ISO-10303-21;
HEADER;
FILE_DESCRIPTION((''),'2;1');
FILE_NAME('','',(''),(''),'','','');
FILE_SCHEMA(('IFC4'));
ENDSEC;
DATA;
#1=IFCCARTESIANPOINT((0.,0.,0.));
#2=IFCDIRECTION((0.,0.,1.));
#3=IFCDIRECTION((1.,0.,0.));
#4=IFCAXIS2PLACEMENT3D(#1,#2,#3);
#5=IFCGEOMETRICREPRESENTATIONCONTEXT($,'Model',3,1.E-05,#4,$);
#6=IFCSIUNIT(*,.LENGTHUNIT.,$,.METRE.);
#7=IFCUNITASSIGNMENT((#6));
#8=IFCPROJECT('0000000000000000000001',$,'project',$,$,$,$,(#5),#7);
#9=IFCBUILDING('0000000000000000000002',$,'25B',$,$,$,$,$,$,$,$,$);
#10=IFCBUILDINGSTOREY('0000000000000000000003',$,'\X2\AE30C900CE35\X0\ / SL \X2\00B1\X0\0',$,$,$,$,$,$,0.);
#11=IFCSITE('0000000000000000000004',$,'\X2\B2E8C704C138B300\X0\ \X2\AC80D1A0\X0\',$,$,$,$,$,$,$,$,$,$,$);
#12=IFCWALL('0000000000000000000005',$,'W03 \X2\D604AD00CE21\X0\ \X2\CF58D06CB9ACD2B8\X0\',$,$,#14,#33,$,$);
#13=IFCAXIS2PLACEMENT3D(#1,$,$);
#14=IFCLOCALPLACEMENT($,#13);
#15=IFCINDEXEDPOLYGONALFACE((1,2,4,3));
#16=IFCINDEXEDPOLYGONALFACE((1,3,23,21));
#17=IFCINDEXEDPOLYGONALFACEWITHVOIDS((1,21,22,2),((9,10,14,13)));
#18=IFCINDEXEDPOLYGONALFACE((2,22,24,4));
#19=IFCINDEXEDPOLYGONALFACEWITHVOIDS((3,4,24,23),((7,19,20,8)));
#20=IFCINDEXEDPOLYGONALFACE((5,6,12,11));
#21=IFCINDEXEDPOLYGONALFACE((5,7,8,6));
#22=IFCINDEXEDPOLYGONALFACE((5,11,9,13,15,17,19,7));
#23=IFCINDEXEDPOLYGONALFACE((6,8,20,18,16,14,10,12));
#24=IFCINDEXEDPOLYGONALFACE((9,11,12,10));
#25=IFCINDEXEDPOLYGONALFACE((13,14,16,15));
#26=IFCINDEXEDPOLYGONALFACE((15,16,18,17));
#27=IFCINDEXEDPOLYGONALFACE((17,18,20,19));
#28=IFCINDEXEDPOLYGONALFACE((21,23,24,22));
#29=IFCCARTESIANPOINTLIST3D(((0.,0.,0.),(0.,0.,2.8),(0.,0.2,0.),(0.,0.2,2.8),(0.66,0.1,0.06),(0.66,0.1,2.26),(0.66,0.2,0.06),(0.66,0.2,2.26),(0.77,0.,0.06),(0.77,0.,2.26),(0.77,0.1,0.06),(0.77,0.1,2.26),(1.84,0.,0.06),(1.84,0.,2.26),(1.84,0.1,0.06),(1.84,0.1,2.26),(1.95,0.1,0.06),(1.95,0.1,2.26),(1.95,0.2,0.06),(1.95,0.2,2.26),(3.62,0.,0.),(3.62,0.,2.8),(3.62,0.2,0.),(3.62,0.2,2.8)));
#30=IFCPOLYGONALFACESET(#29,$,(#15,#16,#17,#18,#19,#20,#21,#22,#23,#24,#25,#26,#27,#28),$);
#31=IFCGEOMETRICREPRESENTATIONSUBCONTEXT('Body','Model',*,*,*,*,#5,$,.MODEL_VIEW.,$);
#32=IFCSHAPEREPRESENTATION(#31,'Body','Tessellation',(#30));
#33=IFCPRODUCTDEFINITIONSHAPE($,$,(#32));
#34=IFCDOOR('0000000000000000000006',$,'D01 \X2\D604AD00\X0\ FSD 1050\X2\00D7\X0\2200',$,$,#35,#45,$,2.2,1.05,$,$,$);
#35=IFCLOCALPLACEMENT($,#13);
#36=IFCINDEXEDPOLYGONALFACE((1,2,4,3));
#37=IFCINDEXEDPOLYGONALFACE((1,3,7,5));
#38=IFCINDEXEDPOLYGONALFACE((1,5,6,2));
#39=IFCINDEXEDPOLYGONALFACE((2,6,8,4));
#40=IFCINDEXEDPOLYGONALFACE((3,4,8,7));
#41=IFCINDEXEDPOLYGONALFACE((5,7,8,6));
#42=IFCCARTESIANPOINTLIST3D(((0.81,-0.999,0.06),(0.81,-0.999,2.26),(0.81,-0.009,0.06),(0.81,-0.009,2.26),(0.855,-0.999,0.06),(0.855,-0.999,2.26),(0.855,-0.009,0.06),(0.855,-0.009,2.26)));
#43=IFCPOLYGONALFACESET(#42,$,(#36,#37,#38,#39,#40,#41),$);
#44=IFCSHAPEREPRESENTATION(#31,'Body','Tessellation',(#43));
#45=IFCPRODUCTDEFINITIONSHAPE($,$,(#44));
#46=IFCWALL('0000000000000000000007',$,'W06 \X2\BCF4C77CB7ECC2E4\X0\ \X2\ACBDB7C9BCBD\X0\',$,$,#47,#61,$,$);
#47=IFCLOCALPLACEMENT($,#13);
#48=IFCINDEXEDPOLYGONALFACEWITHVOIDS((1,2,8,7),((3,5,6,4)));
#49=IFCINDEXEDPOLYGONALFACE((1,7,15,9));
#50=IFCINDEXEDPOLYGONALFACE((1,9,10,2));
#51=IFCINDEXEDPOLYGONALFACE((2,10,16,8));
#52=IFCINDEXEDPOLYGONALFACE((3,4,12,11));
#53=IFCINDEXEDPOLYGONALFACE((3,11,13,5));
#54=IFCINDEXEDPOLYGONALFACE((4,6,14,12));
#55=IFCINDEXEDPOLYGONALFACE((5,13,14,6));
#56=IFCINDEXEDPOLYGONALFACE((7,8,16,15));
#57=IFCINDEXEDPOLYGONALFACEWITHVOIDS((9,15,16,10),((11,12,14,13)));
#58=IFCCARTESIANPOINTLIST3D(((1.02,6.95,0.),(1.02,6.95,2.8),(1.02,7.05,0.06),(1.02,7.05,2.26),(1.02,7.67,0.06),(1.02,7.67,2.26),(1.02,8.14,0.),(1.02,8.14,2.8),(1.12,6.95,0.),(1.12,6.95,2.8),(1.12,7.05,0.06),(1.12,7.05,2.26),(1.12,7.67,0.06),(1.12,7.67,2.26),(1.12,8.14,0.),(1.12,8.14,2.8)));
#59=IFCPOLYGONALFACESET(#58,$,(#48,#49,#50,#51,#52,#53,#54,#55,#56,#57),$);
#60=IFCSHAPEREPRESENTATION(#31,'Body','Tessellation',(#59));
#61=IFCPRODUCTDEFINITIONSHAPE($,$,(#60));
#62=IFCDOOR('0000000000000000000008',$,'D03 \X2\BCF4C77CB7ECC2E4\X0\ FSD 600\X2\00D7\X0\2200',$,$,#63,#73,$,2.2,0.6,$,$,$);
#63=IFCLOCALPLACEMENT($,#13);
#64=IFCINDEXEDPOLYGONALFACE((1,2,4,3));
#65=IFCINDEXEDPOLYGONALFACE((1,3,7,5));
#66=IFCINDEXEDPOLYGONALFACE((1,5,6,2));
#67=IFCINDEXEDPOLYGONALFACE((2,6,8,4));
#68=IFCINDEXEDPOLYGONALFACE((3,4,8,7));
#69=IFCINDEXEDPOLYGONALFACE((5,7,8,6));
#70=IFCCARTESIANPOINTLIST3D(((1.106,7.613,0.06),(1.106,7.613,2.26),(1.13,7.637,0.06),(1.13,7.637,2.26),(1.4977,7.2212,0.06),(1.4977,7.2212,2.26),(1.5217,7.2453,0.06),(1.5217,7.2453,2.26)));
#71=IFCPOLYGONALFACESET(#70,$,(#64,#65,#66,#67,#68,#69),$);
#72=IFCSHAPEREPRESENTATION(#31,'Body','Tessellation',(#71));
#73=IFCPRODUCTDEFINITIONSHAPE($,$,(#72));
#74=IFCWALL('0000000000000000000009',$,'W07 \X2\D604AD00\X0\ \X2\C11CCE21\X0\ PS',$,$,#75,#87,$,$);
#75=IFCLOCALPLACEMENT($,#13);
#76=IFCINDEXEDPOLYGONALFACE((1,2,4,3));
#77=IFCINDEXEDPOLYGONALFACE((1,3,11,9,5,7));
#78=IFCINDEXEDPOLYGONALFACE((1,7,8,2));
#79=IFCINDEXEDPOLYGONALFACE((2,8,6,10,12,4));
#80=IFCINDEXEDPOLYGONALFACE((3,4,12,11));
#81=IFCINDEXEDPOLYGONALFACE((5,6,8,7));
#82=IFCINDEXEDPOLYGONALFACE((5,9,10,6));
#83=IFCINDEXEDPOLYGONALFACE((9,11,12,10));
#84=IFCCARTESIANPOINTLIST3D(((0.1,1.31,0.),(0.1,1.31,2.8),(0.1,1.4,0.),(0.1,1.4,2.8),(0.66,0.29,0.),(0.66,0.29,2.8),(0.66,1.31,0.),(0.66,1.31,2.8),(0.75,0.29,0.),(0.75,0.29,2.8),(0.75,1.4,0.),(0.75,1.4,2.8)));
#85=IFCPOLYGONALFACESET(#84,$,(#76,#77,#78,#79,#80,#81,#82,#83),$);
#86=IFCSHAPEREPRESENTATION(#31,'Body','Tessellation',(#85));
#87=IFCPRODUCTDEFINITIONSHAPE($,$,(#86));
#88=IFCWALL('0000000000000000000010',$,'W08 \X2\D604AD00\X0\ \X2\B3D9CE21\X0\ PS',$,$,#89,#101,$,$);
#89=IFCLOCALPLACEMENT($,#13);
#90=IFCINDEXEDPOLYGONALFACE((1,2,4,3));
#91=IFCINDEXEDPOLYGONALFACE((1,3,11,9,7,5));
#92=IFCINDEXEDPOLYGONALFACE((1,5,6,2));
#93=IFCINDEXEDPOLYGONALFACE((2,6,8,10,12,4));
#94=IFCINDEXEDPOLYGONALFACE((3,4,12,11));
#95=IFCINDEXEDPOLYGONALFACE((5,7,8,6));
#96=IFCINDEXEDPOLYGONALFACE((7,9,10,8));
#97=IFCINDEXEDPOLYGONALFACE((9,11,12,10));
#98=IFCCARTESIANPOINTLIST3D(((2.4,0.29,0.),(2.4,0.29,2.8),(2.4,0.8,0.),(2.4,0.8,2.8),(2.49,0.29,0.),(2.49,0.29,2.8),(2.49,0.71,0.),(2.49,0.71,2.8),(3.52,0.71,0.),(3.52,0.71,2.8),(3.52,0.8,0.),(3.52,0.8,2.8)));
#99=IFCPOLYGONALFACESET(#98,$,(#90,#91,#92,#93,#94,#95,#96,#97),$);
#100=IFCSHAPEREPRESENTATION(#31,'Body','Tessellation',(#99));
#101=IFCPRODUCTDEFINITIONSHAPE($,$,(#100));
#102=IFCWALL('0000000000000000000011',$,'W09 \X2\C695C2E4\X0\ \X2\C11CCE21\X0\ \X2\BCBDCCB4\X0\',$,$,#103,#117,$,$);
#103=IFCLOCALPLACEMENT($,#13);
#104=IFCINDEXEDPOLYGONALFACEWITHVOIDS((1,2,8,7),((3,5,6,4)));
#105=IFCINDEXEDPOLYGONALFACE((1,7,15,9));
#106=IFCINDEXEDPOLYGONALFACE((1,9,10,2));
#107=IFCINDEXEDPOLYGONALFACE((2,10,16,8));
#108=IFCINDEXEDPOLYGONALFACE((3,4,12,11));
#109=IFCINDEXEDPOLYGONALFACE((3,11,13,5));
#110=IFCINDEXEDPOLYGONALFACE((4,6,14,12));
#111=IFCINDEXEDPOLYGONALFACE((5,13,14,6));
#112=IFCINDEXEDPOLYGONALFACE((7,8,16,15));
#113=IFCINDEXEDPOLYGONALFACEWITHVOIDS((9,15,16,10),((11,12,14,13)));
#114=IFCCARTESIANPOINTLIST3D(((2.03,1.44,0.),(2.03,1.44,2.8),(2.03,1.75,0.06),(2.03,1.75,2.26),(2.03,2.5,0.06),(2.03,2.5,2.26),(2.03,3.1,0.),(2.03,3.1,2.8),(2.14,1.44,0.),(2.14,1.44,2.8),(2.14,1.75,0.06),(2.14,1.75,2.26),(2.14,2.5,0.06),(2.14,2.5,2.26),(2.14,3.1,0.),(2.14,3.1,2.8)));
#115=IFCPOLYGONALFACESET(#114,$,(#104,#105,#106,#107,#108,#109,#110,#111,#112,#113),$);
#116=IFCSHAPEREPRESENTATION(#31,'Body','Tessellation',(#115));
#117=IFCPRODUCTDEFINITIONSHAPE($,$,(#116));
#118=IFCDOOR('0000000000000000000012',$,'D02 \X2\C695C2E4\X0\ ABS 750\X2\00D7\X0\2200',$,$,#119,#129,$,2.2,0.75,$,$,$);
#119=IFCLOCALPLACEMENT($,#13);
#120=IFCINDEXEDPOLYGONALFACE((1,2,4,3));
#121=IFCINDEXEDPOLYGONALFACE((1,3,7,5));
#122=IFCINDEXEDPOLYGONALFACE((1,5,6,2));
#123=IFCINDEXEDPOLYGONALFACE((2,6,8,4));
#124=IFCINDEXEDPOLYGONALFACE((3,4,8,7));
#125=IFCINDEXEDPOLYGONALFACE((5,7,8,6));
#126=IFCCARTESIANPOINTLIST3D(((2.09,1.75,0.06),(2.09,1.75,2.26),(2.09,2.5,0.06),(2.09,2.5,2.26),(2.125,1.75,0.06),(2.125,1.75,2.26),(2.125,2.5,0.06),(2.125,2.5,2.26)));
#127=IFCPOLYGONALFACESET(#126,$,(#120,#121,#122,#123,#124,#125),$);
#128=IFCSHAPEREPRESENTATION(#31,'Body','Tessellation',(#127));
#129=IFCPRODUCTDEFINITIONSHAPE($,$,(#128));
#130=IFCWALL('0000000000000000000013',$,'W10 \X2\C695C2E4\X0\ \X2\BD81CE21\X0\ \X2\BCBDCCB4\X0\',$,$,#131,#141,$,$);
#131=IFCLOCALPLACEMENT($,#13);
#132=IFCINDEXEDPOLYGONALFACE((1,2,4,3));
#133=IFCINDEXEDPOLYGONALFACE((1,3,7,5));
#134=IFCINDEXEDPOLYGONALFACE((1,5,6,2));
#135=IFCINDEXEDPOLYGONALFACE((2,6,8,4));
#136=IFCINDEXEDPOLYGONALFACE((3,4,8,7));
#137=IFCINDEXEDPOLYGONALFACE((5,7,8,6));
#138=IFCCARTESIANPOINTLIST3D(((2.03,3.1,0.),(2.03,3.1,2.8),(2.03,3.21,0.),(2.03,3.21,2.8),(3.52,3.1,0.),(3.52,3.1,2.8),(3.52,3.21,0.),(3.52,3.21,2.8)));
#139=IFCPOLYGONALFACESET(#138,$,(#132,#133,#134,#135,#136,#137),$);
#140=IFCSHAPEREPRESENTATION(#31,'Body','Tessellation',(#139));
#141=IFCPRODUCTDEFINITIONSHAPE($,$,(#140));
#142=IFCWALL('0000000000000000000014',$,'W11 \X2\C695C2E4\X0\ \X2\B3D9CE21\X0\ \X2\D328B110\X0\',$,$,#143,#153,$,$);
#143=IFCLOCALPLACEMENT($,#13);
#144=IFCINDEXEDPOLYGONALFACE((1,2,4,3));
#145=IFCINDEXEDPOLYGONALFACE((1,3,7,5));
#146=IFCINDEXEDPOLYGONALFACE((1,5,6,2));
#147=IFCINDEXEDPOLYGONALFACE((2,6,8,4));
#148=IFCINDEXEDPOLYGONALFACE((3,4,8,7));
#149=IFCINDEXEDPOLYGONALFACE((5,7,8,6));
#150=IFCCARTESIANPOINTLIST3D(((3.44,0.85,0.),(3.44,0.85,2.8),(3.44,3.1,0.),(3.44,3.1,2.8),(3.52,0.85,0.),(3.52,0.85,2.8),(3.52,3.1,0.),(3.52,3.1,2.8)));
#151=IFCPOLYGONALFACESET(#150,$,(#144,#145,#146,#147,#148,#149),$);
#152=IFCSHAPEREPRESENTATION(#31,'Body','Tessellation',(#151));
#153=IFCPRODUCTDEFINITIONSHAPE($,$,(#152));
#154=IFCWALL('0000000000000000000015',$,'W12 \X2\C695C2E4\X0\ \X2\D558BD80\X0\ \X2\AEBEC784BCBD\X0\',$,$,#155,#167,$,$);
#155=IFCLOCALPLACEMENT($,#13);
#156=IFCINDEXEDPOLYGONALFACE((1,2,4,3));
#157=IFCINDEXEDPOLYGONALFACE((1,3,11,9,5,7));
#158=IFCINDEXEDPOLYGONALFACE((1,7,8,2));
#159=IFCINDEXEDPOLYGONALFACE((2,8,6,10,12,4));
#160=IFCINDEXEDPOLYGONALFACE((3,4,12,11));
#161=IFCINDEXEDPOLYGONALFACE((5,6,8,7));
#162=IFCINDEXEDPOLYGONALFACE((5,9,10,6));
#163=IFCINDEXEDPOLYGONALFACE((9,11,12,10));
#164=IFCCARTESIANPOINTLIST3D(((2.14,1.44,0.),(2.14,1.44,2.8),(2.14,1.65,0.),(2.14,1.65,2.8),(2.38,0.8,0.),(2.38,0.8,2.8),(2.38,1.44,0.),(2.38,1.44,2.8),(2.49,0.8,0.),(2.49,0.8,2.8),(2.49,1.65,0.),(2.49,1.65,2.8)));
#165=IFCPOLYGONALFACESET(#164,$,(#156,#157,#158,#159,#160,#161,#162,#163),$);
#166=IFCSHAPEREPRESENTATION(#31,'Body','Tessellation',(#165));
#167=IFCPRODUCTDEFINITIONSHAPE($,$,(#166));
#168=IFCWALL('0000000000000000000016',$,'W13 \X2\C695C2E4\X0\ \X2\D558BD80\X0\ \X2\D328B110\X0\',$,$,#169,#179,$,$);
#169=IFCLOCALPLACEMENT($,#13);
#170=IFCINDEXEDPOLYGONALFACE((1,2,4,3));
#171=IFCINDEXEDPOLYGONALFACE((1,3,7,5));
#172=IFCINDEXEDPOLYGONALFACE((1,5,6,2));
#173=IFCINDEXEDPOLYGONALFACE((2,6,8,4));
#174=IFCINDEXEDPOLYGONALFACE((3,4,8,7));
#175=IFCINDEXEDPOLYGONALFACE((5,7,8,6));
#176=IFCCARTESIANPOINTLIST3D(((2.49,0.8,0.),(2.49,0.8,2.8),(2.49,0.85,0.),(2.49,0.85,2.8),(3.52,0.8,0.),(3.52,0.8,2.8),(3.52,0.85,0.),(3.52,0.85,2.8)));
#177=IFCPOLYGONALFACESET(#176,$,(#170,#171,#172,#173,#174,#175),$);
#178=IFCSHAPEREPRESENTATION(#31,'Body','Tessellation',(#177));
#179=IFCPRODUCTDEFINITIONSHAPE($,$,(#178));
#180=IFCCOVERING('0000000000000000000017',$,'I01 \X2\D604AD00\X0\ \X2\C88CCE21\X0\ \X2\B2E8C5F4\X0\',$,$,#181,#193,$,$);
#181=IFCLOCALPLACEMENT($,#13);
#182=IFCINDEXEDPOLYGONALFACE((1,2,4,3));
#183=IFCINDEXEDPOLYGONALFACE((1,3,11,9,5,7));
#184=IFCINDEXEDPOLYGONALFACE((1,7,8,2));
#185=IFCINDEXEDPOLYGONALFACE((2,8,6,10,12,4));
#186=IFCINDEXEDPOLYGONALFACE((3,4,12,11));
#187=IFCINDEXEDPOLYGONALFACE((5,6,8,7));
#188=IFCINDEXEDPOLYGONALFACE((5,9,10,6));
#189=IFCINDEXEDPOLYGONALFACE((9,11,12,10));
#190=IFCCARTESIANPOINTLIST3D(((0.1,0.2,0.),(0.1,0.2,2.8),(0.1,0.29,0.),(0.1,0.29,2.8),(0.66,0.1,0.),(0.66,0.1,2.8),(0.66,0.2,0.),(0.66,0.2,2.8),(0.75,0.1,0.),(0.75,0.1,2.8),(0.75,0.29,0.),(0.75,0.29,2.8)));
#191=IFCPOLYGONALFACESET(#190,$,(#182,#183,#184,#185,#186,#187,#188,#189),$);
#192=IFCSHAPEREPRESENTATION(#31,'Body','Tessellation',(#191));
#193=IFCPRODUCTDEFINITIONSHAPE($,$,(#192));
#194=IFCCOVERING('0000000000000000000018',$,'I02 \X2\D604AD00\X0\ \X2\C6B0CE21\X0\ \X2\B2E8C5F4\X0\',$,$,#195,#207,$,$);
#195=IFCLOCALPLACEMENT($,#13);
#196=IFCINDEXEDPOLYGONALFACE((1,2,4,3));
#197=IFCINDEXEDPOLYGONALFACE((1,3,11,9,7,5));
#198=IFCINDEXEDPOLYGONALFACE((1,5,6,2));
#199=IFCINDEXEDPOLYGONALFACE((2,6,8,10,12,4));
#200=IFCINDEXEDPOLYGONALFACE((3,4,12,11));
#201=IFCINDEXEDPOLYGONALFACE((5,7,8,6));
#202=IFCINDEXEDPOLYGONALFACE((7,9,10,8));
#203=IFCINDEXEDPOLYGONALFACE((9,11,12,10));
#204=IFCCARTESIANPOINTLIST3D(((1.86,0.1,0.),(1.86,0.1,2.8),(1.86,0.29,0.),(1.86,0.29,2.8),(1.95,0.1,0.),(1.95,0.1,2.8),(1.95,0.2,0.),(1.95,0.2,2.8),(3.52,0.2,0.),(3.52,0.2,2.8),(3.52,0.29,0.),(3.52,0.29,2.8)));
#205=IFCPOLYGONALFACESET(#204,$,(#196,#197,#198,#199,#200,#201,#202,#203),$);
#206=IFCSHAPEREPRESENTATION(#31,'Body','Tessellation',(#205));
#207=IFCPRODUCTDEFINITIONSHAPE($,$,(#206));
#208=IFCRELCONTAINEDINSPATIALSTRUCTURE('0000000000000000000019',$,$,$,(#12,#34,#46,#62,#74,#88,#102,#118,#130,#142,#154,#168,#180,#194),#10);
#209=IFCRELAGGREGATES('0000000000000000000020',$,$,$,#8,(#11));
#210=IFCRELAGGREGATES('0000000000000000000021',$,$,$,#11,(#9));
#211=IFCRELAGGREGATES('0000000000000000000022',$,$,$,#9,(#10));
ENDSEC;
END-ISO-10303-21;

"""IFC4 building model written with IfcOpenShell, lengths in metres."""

from ifc_helpers import new_model, si_unit, frame, origin, origin_with_axes, place, context, subcontext, project, spatial, polyline, outline, extrude, element, fill, save


model = new_model("IFC4")

# Units and contexts
model_context = context("Model", 3, precision=1e-05, world=origin_with_axes())
body_context = subcontext(model_context, "Body", "Model", "MODEL_VIEW")
ifc_project = project(units=[si_unit("LENGTHUNIT", "METRE")], contexts=[model_context])

# Site, building, storey
site = spatial("IfcSite", under=ifc_project, Name="단위세대 검토")
building = spatial("IfcBuilding", under=site, Name="25B")
storey = spatial("IfcBuildingStorey", under=building, Name="기준층 / SL ±0", Elevation=0.0)

# Wall, opening, door
wall_1_placement = place(None, origin_with_axes())
wall_1 = element("IfcWall", 1, at=wall_1_placement, inside=storey, Name="W03 현관측 콘크리트", context=body_context, shape_type="SweptSolid", body=[
    extrude(outline(polyline([(3.62, 0.0), (3.62, 0.2), (0.0, 0.2), (0.0, 0.0), (3.62, 0.0)])), origin(), (0.0, 0.0, 1.0), 2.8),
])
opening_1_placement = place(wall_1_placement, origin_with_axes())
opening_1 = element("IfcOpeningElement", 2, at=opening_1_placement, cuts=wall_1, context=body_context, shape_type="SweptSolid", body=[
    extrude(outline(polyline([(0.77, -0.001), (1.84, -0.001), (1.84, 0.1), (1.95, 0.1), (1.95, 0.201), (0.66, 0.201), (0.66, 0.1), (0.77, 0.1), (0.77, -0.001)])), frame((0.0, 0.0, 0.06)), (0.0, 0.0, 1.0), 2.2),
])
door_1_placement = place(None, origin_with_axes())
door_1 = element("IfcDoor", 3, at=door_1_placement, inside=storey, Name="D01 현관 FSD 1050×2200", OverallHeight=2.2, OverallWidth=1.05, context=body_context, shape_type="SweptSolid", body=[
    extrude(outline(polyline([(0.855, -0.009), (0.855, -0.999), (0.81, -0.999), (0.81, -0.009), (0.855, -0.009)])), frame((0.0, 0.0, 0.06)), (0.0, 0.0, 1.0), 2.2),
])
fill(opening_1, door_1)

# Wall, opening, door
wall_2_placement = place(None, origin_with_axes())
wall_2 = element("IfcWall", 4, at=wall_2_placement, inside=storey, Name="W06 보일러실 경량벽", context=body_context, shape_type="SweptSolid", body=[
    extrude(outline(polyline([(1.12, 6.95), (1.12, 8.14), (1.02, 8.14), (1.02, 6.95), (1.12, 6.95)])), origin(), (0.0, 0.0, 1.0), 2.8),
])
opening_2_placement = place(wall_2_placement, origin_with_axes())
opening_2 = element("IfcOpeningElement", 5, at=opening_2_placement, cuts=wall_2, context=body_context, shape_type="SweptSolid", body=[
    extrude(outline(polyline([(1.121, 7.05), (1.121, 7.67), (1.019, 7.67), (1.019, 7.05), (1.121, 7.05)])), frame((0.0, 0.0, 0.06)), (0.0, 0.0, 1.0), 2.2),
])
door_2_placement = place(None, origin_with_axes())
door_2 = element("IfcDoor", 6, at=door_2_placement, inside=storey, Name="D03 보일러실 FSD 600×2200", OverallHeight=2.2, OverallWidth=0.6, context=body_context, shape_type="SweptSolid", body=[
    extrude(outline(polyline([(1.106, 7.613), (1.13, 7.637), (1.5217, 7.2453), (1.4977, 7.2212), (1.106, 7.613)])), frame((0.0, 0.0, 0.06)), (0.0, 0.0, 1.0), 2.2),
])
fill(opening_2, door_2)

# Walls
wall_3_placement = place(None, origin_with_axes())
element("IfcWall", 7, at=wall_3_placement, inside=storey, Name="W07 현관 서측 PS", context=body_context, shape_type="SweptSolid", body=[
    extrude(outline(polyline([(0.66, 0.29), (0.75, 0.29), (0.75, 1.4), (0.1, 1.4), (0.1, 1.31), (0.66, 1.31), (0.66, 0.29)])), origin(), (0.0, 0.0, 1.0), 2.8),
])
wall_4_placement = place(None, origin_with_axes())
element("IfcWall", 8, at=wall_4_placement, inside=storey, Name="W08 현관 동측 PS", context=body_context, shape_type="SweptSolid", body=[
    extrude(outline(polyline([(2.4, 0.29), (2.49, 0.29), (2.49, 0.71), (3.52, 0.71), (3.52, 0.8), (2.4, 0.8), (2.4, 0.29)])), origin(), (0.0, 0.0, 1.0), 2.8),
])

# Wall, opening, door
wall_5_placement = place(None, origin_with_axes())
wall_5 = element("IfcWall", 9, at=wall_5_placement, inside=storey, Name="W09 욕실 서측 벽체", context=body_context, shape_type="SweptSolid", body=[
    extrude(outline(polyline([(2.14, 1.44), (2.14, 3.1), (2.03, 3.1), (2.03, 1.44), (2.14, 1.44)])), origin(), (0.0, 0.0, 1.0), 2.8),
])
opening_3_placement = place(wall_5_placement, origin_with_axes())
opening_3 = element("IfcOpeningElement", 10, at=opening_3_placement, cuts=wall_5, context=body_context, shape_type="SweptSolid", body=[
    extrude(outline(polyline([(2.141, 1.75), (2.141, 2.5), (2.029, 2.5), (2.029, 1.75), (2.141, 1.75)])), frame((0.0, 0.0, 0.06)), (0.0, 0.0, 1.0), 2.2),
])
door_3_placement = place(None, origin_with_axes())
door_3 = element("IfcDoor", 11, at=door_3_placement, inside=storey, Name="D02 욕실 ABS 750×2200", OverallHeight=2.2, OverallWidth=0.75, context=body_context, shape_type="SweptSolid", body=[
    extrude(outline(polyline([(2.125, 1.75), (2.125, 2.5), (2.09, 2.5), (2.09, 1.75), (2.125, 1.75)])), frame((0.0, 0.0, 0.06)), (0.0, 0.0, 1.0), 2.2),
])
fill(opening_3, door_3)

# Walls
wall_6_placement = place(None, origin_with_axes())
element("IfcWall", 12, at=wall_6_placement, inside=storey, Name="W10 욕실 북측 벽체", context=body_context, shape_type="SweptSolid", body=[
    extrude(outline(polyline([(3.52, 3.1), (3.52, 3.21), (2.03, 3.21), (2.03, 3.1), (3.52, 3.1)])), origin(), (0.0, 0.0, 1.0), 2.8),
])
wall_7_placement = place(None, origin_with_axes())
element("IfcWall", 13, at=wall_7_placement, inside=storey, Name="W11 욕실 동측 패널", context=body_context, shape_type="SweptSolid", body=[
    extrude(outline(polyline([(3.52, 0.85), (3.52, 3.1), (3.44, 3.1), (3.44, 0.85), (3.52, 0.85)])), origin(), (0.0, 0.0, 1.0), 2.8),
])
wall_8_placement = place(None, origin_with_axes())
element("IfcWall", 14, at=wall_8_placement, inside=storey, Name="W12 욕실 하부 꺾임벽", context=body_context, shape_type="SweptSolid", body=[
    extrude(outline(polyline([(2.14, 1.44), (2.38, 1.44), (2.38, 0.8), (2.49, 0.8), (2.49, 1.65), (2.14, 1.65), (2.14, 1.44)])), origin(), (0.0, 0.0, 1.0), 2.8),
])
wall_9_placement = place(None, origin_with_axes())
element("IfcWall", 15, at=wall_9_placement, inside=storey, Name="W13 욕실 하부 패널", context=body_context, shape_type="SweptSolid", body=[
    extrude(outline(polyline([(3.52, 0.8), (3.52, 0.85), (2.49, 0.85), (2.49, 0.8), (3.52, 0.8)])), origin(), (0.0, 0.0, 1.0), 2.8),
])

# Coverings
covering_1_placement = place(None, origin_with_axes())
element("IfcCovering", 16, at=covering_1_placement, inside=storey, Name="I01 현관 좌측 단열", context=body_context, shape_type="SweptSolid", body=[
    extrude(outline(polyline([(0.1, 0.2), (0.66, 0.2), (0.66, 0.1), (0.75, 0.1), (0.75, 0.29), (0.1, 0.29), (0.1, 0.2)])), origin(), (0.0, 0.0, 1.0), 2.8),
])
covering_2_placement = place(None, origin_with_axes())
element("IfcCovering", 17, at=covering_2_placement, inside=storey, Name="I02 현관 우측 단열", context=body_context, shape_type="SweptSolid", body=[
    extrude(outline(polyline([(1.86, 0.1), (1.95, 0.1), (1.95, 0.2), (3.52, 0.2), (3.52, 0.29), (1.86, 0.29), (1.86, 0.1)])), origin(), (0.0, 0.0, 1.0), 2.8),
])

save(model, "model.ifc")
